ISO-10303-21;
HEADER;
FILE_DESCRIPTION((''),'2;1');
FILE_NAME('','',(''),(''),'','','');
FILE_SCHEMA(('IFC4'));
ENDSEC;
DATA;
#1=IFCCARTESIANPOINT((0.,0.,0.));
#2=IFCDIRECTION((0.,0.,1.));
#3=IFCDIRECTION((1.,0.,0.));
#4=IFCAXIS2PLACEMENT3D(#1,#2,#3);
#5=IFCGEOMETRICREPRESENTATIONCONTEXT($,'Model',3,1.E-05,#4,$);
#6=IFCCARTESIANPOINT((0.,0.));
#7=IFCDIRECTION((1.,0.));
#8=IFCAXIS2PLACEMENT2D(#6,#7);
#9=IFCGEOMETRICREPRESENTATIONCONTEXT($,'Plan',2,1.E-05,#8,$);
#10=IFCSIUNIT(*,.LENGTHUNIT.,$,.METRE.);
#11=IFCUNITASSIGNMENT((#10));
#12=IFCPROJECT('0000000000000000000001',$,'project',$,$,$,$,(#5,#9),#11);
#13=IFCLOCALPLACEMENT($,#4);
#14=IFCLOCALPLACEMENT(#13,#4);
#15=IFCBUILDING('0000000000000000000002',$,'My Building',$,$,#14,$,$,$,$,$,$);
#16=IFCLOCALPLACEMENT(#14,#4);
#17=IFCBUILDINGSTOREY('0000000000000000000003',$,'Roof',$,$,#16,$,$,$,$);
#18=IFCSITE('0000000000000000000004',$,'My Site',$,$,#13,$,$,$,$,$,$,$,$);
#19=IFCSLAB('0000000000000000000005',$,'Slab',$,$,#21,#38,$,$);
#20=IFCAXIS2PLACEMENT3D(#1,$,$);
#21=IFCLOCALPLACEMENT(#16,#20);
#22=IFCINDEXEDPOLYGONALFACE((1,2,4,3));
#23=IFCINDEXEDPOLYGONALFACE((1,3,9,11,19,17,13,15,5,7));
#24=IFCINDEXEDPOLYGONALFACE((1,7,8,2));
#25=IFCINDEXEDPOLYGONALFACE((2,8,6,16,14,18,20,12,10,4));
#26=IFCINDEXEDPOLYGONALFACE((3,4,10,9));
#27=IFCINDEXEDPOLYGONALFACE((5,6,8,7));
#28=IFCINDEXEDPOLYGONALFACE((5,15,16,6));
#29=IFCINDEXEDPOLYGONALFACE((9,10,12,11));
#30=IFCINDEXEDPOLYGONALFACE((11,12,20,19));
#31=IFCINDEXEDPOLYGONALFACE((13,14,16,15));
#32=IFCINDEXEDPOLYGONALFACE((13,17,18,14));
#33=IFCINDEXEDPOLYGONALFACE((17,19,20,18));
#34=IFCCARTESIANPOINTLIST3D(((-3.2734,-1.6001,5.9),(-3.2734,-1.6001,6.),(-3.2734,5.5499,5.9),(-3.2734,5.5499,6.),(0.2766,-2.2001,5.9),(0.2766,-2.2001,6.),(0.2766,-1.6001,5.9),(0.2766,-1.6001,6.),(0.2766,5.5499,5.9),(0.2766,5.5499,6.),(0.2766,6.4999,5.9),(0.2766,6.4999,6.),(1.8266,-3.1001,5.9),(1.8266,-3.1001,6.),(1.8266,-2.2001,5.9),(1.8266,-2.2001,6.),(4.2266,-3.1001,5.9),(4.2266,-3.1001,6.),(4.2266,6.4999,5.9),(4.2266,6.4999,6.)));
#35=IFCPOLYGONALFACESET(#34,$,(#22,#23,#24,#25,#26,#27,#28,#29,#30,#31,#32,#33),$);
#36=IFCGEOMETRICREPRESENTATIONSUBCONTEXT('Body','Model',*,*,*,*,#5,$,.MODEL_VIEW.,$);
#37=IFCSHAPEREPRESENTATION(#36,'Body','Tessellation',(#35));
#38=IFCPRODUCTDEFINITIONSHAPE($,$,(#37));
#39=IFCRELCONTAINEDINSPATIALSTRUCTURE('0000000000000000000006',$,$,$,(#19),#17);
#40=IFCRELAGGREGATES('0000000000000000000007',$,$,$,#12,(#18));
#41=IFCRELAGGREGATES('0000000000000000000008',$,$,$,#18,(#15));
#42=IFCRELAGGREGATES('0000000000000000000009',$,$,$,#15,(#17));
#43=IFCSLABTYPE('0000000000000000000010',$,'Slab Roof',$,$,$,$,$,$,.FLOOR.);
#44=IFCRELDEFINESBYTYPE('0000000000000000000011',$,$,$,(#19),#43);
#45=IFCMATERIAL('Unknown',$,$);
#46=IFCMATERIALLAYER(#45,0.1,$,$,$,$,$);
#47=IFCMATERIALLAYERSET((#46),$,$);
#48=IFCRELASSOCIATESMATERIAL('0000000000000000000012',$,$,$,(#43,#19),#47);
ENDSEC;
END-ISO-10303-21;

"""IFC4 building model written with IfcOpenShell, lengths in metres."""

from ifc_helpers import new_model, si_unit, frame, origin_with_axes, origin_2d_with_axis, place, context, subcontext, project, spatial, indexed_curve, outline, extrude, material, layer, layer_set, layer_usage, type_object, element, save


model = new_model("IFC4")

# Units and contexts
model_context = context("Model", 3, precision=1e-05, world=origin_with_axes())
plan_context = context("Plan", 2, precision=1e-05, world=origin_2d_with_axis())
body_context = subcontext(model_context, "Body", "Model", "MODEL_VIEW")
ifc_project = project(units=[si_unit("LENGTHUNIT", "METRE")], contexts=[model_context, plan_context])

# Site, building, storey
site_placement = place(None, origin_with_axes())
site = spatial("IfcSite", under=ifc_project, at=site_placement, Name="My Site")
building_placement = place(site_placement, origin_with_axes())
building = spatial("IfcBuilding", under=site, at=building_placement, Name="My Building")
storey_placement = place(building_placement, origin_with_axes())
storey = spatial("IfcBuildingStorey", under=building, at=storey_placement, Name="Roof")

# Slab
ifc_material = material(Name="Unknown")
ifc_layer = layer(ifc_material, 0.1)
ifc_layer_set = layer_set([ifc_layer])
ifc_layer_usage = layer_usage(ifc_layer_set, "AXIS3", "POSITIVE", -0.1)
slab_type = type_object("IfcSlabType", Name="Slab Roof", PredefinedType="FLOOR", material=ifc_layer_set)
slab_placement = place(storey_placement, frame((4.2266, -3.1001, 6.0), z_axis=(0.0, 0.0, 1.0), x_axis=(1.0, 0.0, 0.0)))
element("IfcSlab", 1, at=slab_placement, inside=storey, type_object=slab_type, material=ifc_layer_usage, Name="Slab", context=body_context, shape_type="SweptSolid", body=[
    extrude(outline(indexed_curve([(0.0, 0.0), (0.0, 9.6), (-3.95, 9.6), (-3.95, 8.65), (-7.5, 8.65), (-7.5, 1.5), (-3.95, 1.5), (-3.95, 0.9), (-2.4, 0.9), (-2.4, 0.0), (0.0, 0.0)])), frame((0.0, 0.0, -0.1), z_axis=(0.0, 0.0, 1.0), x_axis=(1.0, 0.0, 0.0)), (0.0, 0.0, 1.0), 0.1),
])

save(model, "model.ifc")
